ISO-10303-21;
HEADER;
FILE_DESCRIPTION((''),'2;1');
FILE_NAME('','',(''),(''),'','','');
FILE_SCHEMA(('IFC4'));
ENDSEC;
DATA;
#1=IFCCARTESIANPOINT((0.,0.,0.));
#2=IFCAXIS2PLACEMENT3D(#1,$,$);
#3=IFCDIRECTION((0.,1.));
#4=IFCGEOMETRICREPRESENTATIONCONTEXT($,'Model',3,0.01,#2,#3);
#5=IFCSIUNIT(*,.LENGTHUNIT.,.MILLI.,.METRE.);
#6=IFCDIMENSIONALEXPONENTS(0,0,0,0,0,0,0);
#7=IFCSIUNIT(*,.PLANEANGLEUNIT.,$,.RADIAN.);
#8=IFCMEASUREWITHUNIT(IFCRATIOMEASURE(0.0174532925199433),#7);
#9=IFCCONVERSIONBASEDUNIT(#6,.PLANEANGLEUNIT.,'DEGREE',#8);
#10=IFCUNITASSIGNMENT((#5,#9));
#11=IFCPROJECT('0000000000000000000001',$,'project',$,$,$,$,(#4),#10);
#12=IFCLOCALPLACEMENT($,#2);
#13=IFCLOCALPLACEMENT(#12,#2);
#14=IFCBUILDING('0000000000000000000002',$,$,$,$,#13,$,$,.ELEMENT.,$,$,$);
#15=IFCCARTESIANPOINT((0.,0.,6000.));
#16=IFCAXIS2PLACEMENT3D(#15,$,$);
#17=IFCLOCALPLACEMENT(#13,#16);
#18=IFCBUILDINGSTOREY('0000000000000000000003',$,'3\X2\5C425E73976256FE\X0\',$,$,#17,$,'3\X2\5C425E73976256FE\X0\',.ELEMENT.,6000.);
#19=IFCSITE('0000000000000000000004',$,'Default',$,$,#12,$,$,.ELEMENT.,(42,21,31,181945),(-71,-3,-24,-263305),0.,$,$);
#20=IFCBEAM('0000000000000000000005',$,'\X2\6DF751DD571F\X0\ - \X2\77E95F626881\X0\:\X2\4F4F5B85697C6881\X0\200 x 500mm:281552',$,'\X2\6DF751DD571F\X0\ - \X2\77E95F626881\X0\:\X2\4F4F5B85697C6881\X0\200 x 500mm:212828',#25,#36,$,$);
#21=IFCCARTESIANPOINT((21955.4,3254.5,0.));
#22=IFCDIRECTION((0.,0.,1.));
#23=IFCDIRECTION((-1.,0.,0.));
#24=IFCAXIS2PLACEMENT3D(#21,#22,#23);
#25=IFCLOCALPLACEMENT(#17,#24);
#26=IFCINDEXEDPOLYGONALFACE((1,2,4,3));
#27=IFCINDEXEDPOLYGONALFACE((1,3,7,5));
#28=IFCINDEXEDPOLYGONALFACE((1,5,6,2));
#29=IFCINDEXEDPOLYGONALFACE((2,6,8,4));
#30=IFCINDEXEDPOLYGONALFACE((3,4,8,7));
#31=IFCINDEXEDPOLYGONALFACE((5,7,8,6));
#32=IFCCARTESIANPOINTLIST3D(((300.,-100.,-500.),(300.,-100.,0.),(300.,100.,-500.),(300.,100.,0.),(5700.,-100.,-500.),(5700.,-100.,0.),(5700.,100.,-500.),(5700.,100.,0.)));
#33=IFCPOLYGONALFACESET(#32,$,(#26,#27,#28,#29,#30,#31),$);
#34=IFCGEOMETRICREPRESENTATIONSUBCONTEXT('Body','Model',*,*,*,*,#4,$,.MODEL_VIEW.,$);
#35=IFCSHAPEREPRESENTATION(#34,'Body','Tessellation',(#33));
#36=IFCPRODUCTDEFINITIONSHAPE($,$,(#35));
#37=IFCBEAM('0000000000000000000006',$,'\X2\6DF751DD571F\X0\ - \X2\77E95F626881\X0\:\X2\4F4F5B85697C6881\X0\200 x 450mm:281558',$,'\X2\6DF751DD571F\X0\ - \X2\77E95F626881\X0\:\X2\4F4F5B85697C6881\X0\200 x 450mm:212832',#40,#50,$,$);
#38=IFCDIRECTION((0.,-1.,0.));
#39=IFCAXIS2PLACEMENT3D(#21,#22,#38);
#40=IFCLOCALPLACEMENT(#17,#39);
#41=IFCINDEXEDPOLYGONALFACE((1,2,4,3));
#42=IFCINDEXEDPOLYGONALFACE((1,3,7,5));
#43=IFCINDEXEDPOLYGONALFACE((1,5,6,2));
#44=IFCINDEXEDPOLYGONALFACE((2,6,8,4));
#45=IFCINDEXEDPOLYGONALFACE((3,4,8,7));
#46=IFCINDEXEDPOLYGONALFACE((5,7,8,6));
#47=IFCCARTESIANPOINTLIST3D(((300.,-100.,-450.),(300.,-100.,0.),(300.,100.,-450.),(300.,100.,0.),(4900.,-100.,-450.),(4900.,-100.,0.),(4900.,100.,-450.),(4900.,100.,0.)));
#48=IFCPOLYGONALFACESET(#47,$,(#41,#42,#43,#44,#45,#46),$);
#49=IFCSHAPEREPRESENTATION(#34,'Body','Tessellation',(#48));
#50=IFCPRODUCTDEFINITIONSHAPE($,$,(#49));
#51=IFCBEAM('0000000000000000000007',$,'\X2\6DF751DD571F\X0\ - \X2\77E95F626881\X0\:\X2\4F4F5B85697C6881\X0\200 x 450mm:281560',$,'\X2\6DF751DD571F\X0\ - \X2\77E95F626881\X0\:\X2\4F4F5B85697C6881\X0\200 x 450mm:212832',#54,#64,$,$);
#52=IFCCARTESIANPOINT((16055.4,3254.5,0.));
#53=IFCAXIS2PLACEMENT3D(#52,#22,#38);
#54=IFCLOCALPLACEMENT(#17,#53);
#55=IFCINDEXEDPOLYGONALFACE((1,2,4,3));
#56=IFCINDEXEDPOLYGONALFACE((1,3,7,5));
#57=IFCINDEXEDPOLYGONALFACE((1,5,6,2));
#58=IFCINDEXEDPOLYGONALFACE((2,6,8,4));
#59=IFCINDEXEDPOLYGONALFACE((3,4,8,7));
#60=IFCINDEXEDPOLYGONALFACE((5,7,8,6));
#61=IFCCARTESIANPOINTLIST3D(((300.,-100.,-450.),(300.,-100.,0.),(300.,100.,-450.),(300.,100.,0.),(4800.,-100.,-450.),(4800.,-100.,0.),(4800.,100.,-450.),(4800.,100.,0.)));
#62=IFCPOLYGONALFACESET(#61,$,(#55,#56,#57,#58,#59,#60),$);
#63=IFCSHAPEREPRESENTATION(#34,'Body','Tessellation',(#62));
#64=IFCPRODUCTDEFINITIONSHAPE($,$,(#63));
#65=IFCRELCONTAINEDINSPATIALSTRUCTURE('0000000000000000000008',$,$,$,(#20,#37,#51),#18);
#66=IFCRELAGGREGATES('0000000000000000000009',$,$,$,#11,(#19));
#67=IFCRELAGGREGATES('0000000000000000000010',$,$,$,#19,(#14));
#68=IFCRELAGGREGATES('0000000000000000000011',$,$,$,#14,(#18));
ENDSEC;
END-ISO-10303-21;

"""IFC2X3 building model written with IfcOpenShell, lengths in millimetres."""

from ifc_helpers import new_model, entity, si_unit, converted_unit, direction, frame, frame_2d, origin, place, context, subcontext, project, spatial, rectangle, extrude, element, save


model = new_model("IFC2X3")

# Units and contexts
model_context = context("Model", 3, precision=0.01, world=origin(), true_north=direction((0.0, 1.0)))
body_context = subcontext(model_context, "Body", "Model", "MODEL_VIEW")
ifc_project = project(units=[si_unit("LENGTHUNIT", "METRE", prefix="MILLI"), converted_unit("PLANEANGLEUNIT", "DEGREE", entity("IfcRatioMeasure", 0.0174532925199433), si_unit("PLANEANGLEUNIT", "RADIAN"), dimensions=[0, 0, 0, 0, 0, 0, 0])], contexts=[model_context])

# Site, building, storey
site_placement = place(None, origin())
site = spatial("IfcSite", under=ifc_project, at=site_placement, Name="Default", CompositionType="ELEMENT", RefLatitude=(42, 21, 31, 181945), RefLongitude=(-71, -3, -24, -263305), RefElevation=0.0)
building_placement = place(site_placement, origin())
building = spatial("IfcBuilding", under=site, at=building_placement, CompositionType="ELEMENT")
storey_placement = place(building_placement, frame((0.0, 0.0, 6000.0)))
storey = spatial("IfcBuildingStorey", under=building, at=storey_placement, Name="3层平面图", LongName="3层平面图", CompositionType="ELEMENT", Elevation=6000.0)

# Beams
beam_1_placement = place(storey_placement, frame((21955.4, 3254.5, 0.0), z_axis=(0.0, 0.0, 1.0), x_axis=(-1.0, 0.0, 0.0)))
element("IfcBeam", 1, at=beam_1_placement, inside=storey, Name="混凝土 - 矩形梁:住宅楼梁200 x 500mm:281552", ObjectType="混凝土 - 矩形梁:住宅楼梁200 x 500mm:212828", context=body_context, shape_type="SweptSolid", body=[
    extrude(rectangle(XDim=500.0, YDim=200.0, at=frame_2d((0.0, 0.0), x_axis=(1.0, 0.0))), frame((300.0, 0.0, -250.0), z_axis=(1.0, 0.0, 0.0), x_axis=(0.0, 0.0, -1.0)), (0.0, 0.0, 1.0), 5400.0),
])
beam_2_placement = place(storey_placement, frame((21955.4, 3254.5, 0.0), z_axis=(0.0, 0.0, 1.0), x_axis=(0.0, -1.0, 0.0)))
element("IfcBeam", 2, at=beam_2_placement, inside=storey, Name="混凝土 - 矩形梁:住宅楼梁200 x 450mm:281558", ObjectType="混凝土 - 矩形梁:住宅楼梁200 x 450mm:212832", context=body_context, shape_type="SweptSolid", body=[
    extrude(rectangle(XDim=450.0, YDim=200.0, at=frame_2d((0.0, 0.0), x_axis=(1.0, 0.0))), frame((300.0, 0.0, -225.0), z_axis=(1.0, 0.0, 0.0), x_axis=(0.0, 0.0, -1.0)), (0.0, 0.0, 1.0), 4600.0),
])
beam_3_placement = place(storey_placement, frame((16055.4, 3254.5, 0.0), z_axis=(0.0, 0.0, 1.0), x_axis=(0.0, -1.0, 0.0)))
element("IfcBeam", 3, at=beam_3_placement, inside=storey, Name="混凝土 - 矩形梁:住宅楼梁200 x 450mm:281560", ObjectType="混凝土 - 矩形梁:住宅楼梁200 x 450mm:212832", context=body_context, shape_type="SweptSolid", body=[
    extrude(rectangle(XDim=450.0, YDim=200.0, at=frame_2d((0.0, 0.0), x_axis=(1.0, 0.0))), frame((300.0, 0.0, -225.0), z_axis=(1.0, 0.0, 0.0), x_axis=(0.0, 0.0, -1.0)), (0.0, 0.0, 1.0), 4500.0),
])

save(model, "model.ifc")
